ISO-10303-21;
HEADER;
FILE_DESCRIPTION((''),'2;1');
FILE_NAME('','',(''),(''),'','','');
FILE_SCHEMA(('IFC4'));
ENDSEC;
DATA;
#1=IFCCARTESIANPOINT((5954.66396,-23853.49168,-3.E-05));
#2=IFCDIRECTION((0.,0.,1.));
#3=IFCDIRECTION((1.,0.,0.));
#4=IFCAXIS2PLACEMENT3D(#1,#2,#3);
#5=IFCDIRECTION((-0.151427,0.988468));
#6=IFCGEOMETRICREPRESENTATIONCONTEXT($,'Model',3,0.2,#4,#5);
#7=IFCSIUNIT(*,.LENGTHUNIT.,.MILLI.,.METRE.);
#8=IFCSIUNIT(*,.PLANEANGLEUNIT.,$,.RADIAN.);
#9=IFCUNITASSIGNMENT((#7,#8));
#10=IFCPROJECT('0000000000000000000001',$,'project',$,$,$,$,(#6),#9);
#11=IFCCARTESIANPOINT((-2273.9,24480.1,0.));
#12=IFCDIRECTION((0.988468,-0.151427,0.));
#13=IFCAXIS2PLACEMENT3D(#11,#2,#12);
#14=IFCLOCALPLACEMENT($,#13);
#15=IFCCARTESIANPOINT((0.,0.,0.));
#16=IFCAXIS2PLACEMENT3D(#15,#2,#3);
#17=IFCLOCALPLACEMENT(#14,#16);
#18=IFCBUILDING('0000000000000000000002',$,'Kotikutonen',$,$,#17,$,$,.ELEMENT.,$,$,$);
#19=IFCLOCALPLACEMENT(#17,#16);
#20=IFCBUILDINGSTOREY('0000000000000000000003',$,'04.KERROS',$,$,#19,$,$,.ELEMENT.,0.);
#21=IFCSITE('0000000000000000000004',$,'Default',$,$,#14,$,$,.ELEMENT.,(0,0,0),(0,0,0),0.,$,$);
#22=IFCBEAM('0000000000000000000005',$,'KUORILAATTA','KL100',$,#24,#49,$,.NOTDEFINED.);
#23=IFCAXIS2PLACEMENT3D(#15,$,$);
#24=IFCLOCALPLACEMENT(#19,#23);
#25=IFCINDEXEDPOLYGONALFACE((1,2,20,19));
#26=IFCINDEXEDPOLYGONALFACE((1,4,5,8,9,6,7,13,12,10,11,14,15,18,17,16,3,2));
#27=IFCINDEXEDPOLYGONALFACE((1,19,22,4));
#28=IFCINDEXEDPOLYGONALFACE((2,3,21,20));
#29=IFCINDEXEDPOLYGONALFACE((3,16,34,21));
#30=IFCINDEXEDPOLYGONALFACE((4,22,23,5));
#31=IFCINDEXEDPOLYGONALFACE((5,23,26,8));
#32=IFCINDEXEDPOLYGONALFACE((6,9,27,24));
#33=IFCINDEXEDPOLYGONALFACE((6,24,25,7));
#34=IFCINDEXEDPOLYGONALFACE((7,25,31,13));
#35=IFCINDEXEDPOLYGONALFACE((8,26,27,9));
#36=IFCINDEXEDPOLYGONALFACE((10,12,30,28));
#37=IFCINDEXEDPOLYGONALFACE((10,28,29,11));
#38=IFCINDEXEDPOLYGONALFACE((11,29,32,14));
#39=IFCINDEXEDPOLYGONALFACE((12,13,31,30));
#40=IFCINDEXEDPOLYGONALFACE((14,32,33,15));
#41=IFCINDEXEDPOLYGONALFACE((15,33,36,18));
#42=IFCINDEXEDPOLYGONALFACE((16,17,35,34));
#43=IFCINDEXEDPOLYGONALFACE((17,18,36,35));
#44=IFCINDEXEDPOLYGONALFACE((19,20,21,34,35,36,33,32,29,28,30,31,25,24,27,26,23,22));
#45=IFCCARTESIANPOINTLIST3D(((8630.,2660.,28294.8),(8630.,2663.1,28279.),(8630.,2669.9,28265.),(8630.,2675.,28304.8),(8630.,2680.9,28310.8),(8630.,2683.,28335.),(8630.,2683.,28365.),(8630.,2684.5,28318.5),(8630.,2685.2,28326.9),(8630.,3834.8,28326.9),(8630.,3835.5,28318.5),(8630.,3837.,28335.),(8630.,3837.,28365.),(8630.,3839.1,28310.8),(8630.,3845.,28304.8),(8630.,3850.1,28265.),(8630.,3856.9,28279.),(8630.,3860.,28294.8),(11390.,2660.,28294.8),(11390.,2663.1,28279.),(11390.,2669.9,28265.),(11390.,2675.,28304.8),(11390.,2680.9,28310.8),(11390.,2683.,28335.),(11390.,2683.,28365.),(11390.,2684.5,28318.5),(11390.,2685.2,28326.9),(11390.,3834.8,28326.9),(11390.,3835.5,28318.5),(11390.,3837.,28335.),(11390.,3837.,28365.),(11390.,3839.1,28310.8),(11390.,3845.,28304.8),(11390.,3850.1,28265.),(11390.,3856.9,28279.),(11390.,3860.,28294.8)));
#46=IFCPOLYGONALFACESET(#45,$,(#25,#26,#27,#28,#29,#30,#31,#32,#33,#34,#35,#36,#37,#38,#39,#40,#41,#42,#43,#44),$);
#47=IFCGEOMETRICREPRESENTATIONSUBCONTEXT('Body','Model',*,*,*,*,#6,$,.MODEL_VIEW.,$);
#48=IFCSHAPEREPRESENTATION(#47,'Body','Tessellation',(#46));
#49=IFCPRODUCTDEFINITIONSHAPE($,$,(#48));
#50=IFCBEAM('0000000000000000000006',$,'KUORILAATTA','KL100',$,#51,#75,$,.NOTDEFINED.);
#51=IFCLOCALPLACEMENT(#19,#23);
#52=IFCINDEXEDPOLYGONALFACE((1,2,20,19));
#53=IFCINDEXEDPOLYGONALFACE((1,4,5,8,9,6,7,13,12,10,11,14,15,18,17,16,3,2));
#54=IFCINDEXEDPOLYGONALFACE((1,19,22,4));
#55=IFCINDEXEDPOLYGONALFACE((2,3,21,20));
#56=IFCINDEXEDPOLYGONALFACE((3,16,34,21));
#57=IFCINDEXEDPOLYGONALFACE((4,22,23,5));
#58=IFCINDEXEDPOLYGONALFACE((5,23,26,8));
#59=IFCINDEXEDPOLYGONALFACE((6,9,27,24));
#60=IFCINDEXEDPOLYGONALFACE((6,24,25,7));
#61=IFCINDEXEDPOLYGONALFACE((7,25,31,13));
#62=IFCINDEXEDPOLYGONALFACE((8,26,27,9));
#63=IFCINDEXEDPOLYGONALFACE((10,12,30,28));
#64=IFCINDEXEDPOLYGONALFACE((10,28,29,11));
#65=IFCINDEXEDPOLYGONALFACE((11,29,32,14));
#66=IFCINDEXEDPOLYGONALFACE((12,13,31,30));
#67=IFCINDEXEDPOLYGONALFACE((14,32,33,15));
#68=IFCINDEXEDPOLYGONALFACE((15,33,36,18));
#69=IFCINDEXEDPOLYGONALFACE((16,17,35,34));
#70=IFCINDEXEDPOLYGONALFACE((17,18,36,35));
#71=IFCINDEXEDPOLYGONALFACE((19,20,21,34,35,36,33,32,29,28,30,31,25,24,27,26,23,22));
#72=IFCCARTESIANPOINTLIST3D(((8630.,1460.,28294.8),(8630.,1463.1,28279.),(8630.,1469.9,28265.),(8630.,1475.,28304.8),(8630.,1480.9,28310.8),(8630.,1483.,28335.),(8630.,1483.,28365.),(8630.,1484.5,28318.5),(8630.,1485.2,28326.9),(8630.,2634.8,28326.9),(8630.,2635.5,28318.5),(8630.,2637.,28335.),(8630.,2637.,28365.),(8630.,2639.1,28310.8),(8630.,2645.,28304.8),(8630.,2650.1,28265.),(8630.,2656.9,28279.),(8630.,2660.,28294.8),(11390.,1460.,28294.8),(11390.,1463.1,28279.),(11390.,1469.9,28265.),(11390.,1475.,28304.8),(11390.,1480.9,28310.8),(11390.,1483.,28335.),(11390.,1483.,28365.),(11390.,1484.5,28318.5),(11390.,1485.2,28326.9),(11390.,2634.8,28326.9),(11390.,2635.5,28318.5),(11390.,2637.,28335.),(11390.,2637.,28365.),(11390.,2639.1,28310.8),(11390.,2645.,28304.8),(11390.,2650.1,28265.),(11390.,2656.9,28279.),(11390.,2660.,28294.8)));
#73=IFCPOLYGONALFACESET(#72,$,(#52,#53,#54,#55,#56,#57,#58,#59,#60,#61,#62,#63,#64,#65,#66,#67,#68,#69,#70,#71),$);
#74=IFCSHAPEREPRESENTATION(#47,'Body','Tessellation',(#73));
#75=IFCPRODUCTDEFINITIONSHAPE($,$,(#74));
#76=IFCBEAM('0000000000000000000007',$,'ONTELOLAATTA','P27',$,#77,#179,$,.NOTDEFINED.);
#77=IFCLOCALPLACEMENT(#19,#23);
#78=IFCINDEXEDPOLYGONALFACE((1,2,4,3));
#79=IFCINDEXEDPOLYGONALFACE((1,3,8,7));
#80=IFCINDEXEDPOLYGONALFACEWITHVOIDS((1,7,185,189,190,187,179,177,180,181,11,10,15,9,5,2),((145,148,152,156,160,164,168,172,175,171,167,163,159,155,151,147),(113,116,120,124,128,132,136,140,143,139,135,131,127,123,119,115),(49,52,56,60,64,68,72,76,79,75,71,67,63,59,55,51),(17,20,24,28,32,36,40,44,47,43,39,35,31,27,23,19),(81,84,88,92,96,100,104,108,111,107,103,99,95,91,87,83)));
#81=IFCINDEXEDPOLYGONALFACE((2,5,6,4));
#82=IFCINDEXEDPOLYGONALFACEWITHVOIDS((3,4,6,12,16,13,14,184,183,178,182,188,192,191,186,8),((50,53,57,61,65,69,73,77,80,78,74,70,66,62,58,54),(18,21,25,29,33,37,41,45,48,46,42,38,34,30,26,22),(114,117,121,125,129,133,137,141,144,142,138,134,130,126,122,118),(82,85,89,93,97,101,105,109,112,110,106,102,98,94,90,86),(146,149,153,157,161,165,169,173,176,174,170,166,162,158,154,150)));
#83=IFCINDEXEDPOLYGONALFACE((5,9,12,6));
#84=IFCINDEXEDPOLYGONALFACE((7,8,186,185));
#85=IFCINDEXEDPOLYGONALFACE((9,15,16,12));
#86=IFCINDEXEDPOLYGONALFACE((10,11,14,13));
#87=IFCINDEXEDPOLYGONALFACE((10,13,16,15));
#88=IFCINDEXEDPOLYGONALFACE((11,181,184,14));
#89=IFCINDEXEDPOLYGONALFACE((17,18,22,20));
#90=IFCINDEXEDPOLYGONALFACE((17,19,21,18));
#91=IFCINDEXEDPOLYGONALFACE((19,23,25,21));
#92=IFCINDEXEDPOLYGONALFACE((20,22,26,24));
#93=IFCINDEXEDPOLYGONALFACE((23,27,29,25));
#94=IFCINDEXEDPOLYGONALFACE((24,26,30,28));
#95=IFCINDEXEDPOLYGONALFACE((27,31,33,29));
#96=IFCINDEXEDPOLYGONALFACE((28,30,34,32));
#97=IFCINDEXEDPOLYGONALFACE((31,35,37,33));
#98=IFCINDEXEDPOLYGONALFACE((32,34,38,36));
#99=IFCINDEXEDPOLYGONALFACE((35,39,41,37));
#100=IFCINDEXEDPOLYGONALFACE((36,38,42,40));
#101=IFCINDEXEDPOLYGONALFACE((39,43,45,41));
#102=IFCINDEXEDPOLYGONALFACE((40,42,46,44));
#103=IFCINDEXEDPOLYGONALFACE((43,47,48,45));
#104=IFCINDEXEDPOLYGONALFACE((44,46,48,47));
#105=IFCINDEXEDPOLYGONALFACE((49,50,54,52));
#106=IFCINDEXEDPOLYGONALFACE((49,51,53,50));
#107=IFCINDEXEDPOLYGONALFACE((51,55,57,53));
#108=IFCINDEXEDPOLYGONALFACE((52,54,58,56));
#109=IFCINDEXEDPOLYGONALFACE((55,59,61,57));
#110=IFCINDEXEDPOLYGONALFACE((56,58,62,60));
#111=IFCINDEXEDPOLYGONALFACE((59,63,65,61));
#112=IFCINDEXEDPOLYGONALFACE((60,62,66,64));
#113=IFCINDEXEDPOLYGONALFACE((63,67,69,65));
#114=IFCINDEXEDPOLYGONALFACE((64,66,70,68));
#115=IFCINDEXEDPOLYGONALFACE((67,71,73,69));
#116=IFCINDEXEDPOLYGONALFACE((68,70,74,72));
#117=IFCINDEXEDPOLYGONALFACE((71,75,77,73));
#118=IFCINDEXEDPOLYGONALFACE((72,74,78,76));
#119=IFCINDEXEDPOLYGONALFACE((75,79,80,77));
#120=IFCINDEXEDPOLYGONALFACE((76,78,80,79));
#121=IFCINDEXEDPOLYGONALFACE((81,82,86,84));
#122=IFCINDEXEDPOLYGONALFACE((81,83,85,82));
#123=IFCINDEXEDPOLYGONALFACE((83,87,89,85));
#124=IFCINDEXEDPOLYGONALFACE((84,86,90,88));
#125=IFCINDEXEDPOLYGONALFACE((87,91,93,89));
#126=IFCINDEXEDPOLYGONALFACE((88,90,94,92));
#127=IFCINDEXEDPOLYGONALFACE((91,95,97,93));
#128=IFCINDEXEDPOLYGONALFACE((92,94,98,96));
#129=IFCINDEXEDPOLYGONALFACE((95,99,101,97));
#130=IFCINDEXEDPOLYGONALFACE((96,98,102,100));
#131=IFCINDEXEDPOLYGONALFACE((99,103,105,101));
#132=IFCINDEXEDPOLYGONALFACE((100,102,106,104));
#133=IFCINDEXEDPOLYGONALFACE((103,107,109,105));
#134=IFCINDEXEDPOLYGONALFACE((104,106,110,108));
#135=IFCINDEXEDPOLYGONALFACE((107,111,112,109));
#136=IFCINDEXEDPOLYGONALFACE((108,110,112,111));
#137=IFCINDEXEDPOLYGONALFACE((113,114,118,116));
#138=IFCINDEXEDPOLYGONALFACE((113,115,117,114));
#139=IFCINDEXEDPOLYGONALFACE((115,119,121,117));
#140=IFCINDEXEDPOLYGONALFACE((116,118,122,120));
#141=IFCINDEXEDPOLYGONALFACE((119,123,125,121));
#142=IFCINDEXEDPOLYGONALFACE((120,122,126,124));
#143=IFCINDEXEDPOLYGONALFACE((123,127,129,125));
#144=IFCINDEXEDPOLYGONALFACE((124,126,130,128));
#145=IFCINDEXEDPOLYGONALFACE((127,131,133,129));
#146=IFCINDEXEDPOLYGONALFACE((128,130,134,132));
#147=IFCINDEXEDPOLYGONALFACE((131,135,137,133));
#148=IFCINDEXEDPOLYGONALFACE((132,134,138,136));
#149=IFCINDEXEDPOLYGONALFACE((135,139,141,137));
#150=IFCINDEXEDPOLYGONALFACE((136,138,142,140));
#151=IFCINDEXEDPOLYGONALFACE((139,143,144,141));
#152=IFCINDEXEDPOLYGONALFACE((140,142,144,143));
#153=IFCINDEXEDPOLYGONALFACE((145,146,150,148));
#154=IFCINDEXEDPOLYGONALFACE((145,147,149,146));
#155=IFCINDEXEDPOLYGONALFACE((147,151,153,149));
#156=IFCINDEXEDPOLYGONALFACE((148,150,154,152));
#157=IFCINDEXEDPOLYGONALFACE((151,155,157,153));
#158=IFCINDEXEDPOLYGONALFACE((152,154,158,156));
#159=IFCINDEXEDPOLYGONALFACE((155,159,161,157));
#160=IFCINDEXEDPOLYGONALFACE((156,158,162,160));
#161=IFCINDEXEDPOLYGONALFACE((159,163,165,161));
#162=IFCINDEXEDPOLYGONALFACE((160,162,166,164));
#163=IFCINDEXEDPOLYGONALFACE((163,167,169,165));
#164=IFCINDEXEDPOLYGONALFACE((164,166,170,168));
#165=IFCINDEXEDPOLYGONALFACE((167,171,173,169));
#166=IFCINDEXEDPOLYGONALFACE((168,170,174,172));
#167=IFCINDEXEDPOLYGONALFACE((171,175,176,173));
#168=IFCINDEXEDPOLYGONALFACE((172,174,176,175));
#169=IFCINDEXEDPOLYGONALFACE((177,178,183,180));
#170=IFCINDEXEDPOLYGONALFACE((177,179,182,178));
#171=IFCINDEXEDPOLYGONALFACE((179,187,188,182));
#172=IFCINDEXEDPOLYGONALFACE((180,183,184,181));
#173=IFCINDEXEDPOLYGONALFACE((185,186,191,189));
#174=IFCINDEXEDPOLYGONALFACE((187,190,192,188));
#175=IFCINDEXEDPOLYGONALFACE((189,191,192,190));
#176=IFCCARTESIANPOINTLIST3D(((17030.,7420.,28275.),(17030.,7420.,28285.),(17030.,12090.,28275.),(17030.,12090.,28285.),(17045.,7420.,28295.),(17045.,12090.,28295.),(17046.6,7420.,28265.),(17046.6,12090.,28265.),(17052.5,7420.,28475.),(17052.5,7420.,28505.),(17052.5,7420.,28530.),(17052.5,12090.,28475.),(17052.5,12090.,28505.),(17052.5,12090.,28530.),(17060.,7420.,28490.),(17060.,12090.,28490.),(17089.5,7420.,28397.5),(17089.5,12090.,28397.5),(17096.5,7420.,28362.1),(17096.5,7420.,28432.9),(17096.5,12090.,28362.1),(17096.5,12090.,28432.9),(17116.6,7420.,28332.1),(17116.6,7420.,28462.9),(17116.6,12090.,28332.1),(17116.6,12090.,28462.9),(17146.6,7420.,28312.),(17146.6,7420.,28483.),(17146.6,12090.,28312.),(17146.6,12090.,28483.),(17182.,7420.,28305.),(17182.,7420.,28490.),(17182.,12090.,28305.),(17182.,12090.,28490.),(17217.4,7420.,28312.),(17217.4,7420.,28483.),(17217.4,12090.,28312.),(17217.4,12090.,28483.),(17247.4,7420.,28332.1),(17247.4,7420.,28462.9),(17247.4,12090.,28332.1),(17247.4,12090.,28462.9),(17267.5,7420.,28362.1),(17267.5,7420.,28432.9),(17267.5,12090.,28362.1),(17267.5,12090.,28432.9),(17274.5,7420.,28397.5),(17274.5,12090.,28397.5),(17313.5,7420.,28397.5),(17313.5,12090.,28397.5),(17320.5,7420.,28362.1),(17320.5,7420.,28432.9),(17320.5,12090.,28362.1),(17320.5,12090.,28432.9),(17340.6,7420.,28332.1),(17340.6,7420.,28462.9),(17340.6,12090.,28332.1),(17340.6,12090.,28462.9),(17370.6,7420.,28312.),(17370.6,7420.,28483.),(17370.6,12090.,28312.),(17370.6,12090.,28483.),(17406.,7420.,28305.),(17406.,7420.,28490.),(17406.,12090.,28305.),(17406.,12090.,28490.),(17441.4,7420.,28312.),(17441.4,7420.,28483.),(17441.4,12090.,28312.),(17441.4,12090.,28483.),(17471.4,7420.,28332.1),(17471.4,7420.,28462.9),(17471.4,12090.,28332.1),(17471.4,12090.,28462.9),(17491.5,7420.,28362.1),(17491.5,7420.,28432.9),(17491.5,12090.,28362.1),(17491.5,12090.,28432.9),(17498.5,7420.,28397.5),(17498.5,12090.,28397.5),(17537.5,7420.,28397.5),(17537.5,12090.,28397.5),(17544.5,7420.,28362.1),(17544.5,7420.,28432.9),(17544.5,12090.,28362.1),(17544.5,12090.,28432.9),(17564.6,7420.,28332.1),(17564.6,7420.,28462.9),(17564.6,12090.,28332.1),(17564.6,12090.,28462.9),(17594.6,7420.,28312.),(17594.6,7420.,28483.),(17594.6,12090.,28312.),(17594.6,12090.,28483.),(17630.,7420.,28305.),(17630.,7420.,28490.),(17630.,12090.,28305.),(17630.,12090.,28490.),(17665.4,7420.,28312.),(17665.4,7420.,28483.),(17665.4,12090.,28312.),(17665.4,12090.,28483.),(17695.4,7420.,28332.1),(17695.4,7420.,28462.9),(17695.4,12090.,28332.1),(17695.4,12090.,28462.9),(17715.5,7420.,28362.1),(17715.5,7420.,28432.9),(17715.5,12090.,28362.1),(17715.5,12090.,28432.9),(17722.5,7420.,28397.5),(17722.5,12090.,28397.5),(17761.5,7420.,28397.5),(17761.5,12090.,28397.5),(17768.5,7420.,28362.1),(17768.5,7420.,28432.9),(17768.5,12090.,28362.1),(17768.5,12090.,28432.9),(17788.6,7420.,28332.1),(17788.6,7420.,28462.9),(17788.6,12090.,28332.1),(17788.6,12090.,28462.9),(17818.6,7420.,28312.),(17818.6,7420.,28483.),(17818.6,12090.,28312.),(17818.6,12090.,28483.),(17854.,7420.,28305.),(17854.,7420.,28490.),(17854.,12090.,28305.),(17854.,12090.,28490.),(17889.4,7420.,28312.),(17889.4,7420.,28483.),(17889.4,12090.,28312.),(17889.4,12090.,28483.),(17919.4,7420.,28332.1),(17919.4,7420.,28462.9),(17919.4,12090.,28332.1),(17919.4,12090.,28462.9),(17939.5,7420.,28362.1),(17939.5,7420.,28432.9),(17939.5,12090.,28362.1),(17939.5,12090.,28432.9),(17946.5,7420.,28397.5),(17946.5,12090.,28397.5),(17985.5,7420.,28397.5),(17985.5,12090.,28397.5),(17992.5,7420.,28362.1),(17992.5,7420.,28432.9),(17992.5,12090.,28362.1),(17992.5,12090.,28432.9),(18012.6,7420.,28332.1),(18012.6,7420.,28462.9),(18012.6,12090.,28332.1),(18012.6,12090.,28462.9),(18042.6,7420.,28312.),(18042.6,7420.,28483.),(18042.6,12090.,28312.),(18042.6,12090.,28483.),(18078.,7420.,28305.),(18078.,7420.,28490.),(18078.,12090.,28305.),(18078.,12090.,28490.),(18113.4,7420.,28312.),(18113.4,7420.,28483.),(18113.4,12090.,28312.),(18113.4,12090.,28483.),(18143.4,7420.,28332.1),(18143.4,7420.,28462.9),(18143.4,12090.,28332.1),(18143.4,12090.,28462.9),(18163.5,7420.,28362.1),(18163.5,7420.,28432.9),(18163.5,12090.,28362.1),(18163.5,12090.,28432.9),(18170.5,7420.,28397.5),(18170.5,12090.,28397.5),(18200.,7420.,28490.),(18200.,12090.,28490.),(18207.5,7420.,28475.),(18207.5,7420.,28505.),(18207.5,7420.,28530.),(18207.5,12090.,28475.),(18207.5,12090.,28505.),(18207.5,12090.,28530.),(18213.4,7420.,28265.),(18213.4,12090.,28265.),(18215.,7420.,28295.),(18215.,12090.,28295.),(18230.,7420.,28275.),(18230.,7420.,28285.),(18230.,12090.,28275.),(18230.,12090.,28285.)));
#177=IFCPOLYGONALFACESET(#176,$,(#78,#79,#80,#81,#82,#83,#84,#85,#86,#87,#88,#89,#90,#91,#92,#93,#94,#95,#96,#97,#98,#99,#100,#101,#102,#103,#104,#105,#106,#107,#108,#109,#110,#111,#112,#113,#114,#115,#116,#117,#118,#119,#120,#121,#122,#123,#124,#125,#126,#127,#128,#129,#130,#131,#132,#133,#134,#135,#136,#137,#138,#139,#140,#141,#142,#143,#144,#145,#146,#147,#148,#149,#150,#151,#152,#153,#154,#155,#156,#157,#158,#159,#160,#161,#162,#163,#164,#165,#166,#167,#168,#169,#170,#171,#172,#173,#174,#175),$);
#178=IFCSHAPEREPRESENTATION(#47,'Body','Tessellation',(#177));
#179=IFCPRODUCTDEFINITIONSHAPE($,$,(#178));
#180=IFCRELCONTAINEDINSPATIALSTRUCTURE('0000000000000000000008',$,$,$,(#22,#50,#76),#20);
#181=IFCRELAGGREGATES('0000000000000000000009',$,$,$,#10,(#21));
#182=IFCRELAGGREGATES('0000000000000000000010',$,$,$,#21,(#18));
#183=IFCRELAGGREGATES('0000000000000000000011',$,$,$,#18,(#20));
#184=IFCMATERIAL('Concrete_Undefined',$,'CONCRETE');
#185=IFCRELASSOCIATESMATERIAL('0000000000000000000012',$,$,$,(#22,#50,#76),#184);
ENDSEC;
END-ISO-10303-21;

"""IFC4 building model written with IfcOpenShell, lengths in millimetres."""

from ifc_helpers import new_model, si_unit, direction, frame, origin_with_axes, place, context, subcontext, project, spatial, line, indexed_curve, outline, extrude, material, element, save


model = new_model("IFC4")

# Units and contexts
model_context = context("Model", 3, precision=0.2, world=frame((5954.66396, -23853.49168, -3e-05), z_axis=(0.0, 0.0, 1.0), x_axis=(1.0, 0.0, 0.0)), true_north=direction((-0.151427, 0.988468)))
body_context = subcontext(model_context, "Body", "Model", "MODEL_VIEW")
ifc_project = project(units=[si_unit("LENGTHUNIT", "METRE", prefix="MILLI"), si_unit("PLANEANGLEUNIT", "RADIAN")], contexts=[model_context])

# Site, building, storey
site_placement = place(None, frame((-2273.9, 24480.1, 0.0), z_axis=(0.0, 0.0, 1.0), x_axis=(0.988468, -0.151427, 0.0)))
site = spatial("IfcSite", under=ifc_project, at=site_placement, Name="Default", CompositionType="ELEMENT", RefLatitude=(0, 0, 0), RefLongitude=(0, 0, 0), RefElevation=0.0)
building_placement = place(site_placement, origin_with_axes())
building = spatial("IfcBuilding", under=site, at=building_placement, Name="Kotikutonen", CompositionType="ELEMENT")
storey_placement = place(building_placement, origin_with_axes())
storey = spatial("IfcBuildingStorey", under=building, at=storey_placement, Name="04.KERROS", CompositionType="ELEMENT", Elevation=0.0)

# Beams
ifc_material_1 = material(Name="Concrete_Undefined", Category="CONCRETE")
for number, where, z_axis, x_axis, name in (
    (1, (11390.0, 3260.0, 28315.0), (0.0, 1.0, 0.0), (-1.0, 0.0, 0.0), "KUORILAATTA"),
    (2, (11390.0, 2060.0, 28315.0), (0.0, 1.0, 0.0), (-1.0, 0.0, 0.0), "KUORILAATTA"),
):
    element("IfcBeam", number, at=place(storey_placement, frame(where, z_axis=z_axis, x_axis=x_axis)), inside=storey, material=ifc_material_1, Name=name, Description="KL100", PredefinedType="NOTDEFINED", context=body_context, shape_type="SolidModel", body=[
        extrude(outline(indexed_curve([(-596.9, -36.0), (-590.1, -50.0), (590.1, -50.0), (596.9, -36.0), (600.0, -20.2), (585.0, -10.2), (579.1, -4.2), (575.5, 3.5), (574.8, 11.9), (577.0, 20.0), (577.0, 50.0), (-577.0, 50.0), (-577.0, 20.0), (-574.8, 11.9), (-575.5, 3.5), (-579.1, -4.2), (-585.0, -10.2), (-600.0, -20.2)], segments=[line(1, 2, 3, 4, 5, 6, 7, 8, 9, 10, 11, 12, 13, 14, 15, 16, 17, 18, 1)])), frame((0.0, 0.0, 0.0), z_axis=(-1.0, 0.0, 0.0), x_axis=(0.0, 0.0, 1.0)), (0.0, 0.0, -1.0), 2760.0),
    ])
beam_1_placement = place(storey_placement, frame((17630.0, 12090.0, 28397.5), z_axis=(-1.0, 0.0, 0.0), x_axis=(0.0, -1.0, 0.0)))
element("IfcBeam", 3, at=beam_1_placement, inside=storey, material=ifc_material_1, Name="ONTELOLAATTA", Description="P27", PredefinedType="NOTDEFINED", context=body_context, shape_type="SolidModel", body=[
    extrude(outline(indexed_curve([(-600.0, -122.5), (-583.4, -132.5), (583.4, -132.5), (600.0, -122.5), (600.0, -112.5), (585.0, -102.5), (577.5, 77.5), (570.0, 92.5), (577.5, 107.5), (577.5, 132.5), (-577.5, 132.5), (-577.5, 107.5), (-570.0, 92.5), (-577.5, 77.5), (-585.0, -102.5), (-600.0, -112.5)], segments=[line(1, 2, 3, 4, 5, 6, 7, 8, 9, 10, 11, 12, 13, 14, 15, 16, 1)]), holes=[indexed_curve([(-448.0, -92.5), (-483.4, -85.5), (-513.4, -65.4), (-533.5, -35.4), (-540.5, 0.0), (-533.5, 35.4), (-513.4, 65.4), (-483.4, 85.5), (-448.0, 92.5), (-412.6, 85.5), (-382.6, 65.4), (-362.5, 35.4), (-355.5, 0.0), (-362.5, -35.4), (-382.6, -65.4), (-412.6, -85.5)], segments=[line(1, 2, 3, 4, 5, 6, 7, 8, 9, 10, 11, 12, 13, 14, 15, 16, 1)]), indexed_curve([(-224.0, -92.5), (-259.4, -85.5), (-289.4, -65.4), (-309.5, -35.4), (-316.5, 0.0), (-309.5, 35.4), (-289.4, 65.4), (-259.4, 85.5), (-224.0, 92.5), (-188.6, 85.5), (-158.6, 65.4), (-138.5, 35.4), (-131.5, 0.0), (-138.5, -35.4), (-158.6, -65.4), (-188.6, -85.5)], segments=[line(1, 2, 3, 4, 5, 6, 7, 8, 9, 10, 11, 12, 13, 14, 15, 16, 1)]), indexed_curve([(0.0, -92.5), (-35.4, -85.5), (-65.4, -65.4), (-85.5, -35.4), (-92.5, 0.0), (-85.5, 35.4), (-65.4, 65.4), (-35.4, 85.5), (0.0, 92.5), (35.4, 85.5), (65.4, 65.4), (85.5, 35.4), (92.5, 0.0), (85.5, -35.4), (65.4, -65.4), (35.4, -85.5)], segments=[line(1, 2, 3, 4, 5, 6, 7, 8, 9, 10, 11, 12, 13, 14, 15, 16, 1)]), indexed_curve([(224.0, -92.5), (188.6, -85.5), (158.6, -65.4), (138.5, -35.4), (131.5, 0.0), (138.5, 35.4), (158.6, 65.4), (188.6, 85.5), (224.0, 92.5), (259.4, 85.5), (289.4, 65.4), (309.5, 35.4), (316.5, 0.0), (309.5, -35.4), (289.4, -65.4), (259.4, -85.5)], segments=[line(1, 2, 3, 4, 5, 6, 7, 8, 9, 10, 11, 12, 13, 14, 15, 16, 1)]), indexed_curve([(448.0, -92.5), (412.6, -85.5), (382.6, -65.4), (362.5, -35.4), (355.5, 0.0), (362.5, 35.4), (382.6, 65.4), (412.6, 85.5), (448.0, 92.5), (483.4, 85.5), (513.4, 65.4), (533.5, 35.4), (540.5, 0.0), (533.5, -35.4), (513.4, -65.4), (483.4, -85.5)], segments=[line(1, 2, 3, 4, 5, 6, 7, 8, 9, 10, 11, 12, 13, 14, 15, 16, 1)])]), frame((0.0, 0.0, 0.0), z_axis=(-1.0, 0.0, 0.0), x_axis=(0.0, 0.0, 1.0)), (0.0, 0.0, -1.0), 4670.0),
])

save(model, "model.ifc")
